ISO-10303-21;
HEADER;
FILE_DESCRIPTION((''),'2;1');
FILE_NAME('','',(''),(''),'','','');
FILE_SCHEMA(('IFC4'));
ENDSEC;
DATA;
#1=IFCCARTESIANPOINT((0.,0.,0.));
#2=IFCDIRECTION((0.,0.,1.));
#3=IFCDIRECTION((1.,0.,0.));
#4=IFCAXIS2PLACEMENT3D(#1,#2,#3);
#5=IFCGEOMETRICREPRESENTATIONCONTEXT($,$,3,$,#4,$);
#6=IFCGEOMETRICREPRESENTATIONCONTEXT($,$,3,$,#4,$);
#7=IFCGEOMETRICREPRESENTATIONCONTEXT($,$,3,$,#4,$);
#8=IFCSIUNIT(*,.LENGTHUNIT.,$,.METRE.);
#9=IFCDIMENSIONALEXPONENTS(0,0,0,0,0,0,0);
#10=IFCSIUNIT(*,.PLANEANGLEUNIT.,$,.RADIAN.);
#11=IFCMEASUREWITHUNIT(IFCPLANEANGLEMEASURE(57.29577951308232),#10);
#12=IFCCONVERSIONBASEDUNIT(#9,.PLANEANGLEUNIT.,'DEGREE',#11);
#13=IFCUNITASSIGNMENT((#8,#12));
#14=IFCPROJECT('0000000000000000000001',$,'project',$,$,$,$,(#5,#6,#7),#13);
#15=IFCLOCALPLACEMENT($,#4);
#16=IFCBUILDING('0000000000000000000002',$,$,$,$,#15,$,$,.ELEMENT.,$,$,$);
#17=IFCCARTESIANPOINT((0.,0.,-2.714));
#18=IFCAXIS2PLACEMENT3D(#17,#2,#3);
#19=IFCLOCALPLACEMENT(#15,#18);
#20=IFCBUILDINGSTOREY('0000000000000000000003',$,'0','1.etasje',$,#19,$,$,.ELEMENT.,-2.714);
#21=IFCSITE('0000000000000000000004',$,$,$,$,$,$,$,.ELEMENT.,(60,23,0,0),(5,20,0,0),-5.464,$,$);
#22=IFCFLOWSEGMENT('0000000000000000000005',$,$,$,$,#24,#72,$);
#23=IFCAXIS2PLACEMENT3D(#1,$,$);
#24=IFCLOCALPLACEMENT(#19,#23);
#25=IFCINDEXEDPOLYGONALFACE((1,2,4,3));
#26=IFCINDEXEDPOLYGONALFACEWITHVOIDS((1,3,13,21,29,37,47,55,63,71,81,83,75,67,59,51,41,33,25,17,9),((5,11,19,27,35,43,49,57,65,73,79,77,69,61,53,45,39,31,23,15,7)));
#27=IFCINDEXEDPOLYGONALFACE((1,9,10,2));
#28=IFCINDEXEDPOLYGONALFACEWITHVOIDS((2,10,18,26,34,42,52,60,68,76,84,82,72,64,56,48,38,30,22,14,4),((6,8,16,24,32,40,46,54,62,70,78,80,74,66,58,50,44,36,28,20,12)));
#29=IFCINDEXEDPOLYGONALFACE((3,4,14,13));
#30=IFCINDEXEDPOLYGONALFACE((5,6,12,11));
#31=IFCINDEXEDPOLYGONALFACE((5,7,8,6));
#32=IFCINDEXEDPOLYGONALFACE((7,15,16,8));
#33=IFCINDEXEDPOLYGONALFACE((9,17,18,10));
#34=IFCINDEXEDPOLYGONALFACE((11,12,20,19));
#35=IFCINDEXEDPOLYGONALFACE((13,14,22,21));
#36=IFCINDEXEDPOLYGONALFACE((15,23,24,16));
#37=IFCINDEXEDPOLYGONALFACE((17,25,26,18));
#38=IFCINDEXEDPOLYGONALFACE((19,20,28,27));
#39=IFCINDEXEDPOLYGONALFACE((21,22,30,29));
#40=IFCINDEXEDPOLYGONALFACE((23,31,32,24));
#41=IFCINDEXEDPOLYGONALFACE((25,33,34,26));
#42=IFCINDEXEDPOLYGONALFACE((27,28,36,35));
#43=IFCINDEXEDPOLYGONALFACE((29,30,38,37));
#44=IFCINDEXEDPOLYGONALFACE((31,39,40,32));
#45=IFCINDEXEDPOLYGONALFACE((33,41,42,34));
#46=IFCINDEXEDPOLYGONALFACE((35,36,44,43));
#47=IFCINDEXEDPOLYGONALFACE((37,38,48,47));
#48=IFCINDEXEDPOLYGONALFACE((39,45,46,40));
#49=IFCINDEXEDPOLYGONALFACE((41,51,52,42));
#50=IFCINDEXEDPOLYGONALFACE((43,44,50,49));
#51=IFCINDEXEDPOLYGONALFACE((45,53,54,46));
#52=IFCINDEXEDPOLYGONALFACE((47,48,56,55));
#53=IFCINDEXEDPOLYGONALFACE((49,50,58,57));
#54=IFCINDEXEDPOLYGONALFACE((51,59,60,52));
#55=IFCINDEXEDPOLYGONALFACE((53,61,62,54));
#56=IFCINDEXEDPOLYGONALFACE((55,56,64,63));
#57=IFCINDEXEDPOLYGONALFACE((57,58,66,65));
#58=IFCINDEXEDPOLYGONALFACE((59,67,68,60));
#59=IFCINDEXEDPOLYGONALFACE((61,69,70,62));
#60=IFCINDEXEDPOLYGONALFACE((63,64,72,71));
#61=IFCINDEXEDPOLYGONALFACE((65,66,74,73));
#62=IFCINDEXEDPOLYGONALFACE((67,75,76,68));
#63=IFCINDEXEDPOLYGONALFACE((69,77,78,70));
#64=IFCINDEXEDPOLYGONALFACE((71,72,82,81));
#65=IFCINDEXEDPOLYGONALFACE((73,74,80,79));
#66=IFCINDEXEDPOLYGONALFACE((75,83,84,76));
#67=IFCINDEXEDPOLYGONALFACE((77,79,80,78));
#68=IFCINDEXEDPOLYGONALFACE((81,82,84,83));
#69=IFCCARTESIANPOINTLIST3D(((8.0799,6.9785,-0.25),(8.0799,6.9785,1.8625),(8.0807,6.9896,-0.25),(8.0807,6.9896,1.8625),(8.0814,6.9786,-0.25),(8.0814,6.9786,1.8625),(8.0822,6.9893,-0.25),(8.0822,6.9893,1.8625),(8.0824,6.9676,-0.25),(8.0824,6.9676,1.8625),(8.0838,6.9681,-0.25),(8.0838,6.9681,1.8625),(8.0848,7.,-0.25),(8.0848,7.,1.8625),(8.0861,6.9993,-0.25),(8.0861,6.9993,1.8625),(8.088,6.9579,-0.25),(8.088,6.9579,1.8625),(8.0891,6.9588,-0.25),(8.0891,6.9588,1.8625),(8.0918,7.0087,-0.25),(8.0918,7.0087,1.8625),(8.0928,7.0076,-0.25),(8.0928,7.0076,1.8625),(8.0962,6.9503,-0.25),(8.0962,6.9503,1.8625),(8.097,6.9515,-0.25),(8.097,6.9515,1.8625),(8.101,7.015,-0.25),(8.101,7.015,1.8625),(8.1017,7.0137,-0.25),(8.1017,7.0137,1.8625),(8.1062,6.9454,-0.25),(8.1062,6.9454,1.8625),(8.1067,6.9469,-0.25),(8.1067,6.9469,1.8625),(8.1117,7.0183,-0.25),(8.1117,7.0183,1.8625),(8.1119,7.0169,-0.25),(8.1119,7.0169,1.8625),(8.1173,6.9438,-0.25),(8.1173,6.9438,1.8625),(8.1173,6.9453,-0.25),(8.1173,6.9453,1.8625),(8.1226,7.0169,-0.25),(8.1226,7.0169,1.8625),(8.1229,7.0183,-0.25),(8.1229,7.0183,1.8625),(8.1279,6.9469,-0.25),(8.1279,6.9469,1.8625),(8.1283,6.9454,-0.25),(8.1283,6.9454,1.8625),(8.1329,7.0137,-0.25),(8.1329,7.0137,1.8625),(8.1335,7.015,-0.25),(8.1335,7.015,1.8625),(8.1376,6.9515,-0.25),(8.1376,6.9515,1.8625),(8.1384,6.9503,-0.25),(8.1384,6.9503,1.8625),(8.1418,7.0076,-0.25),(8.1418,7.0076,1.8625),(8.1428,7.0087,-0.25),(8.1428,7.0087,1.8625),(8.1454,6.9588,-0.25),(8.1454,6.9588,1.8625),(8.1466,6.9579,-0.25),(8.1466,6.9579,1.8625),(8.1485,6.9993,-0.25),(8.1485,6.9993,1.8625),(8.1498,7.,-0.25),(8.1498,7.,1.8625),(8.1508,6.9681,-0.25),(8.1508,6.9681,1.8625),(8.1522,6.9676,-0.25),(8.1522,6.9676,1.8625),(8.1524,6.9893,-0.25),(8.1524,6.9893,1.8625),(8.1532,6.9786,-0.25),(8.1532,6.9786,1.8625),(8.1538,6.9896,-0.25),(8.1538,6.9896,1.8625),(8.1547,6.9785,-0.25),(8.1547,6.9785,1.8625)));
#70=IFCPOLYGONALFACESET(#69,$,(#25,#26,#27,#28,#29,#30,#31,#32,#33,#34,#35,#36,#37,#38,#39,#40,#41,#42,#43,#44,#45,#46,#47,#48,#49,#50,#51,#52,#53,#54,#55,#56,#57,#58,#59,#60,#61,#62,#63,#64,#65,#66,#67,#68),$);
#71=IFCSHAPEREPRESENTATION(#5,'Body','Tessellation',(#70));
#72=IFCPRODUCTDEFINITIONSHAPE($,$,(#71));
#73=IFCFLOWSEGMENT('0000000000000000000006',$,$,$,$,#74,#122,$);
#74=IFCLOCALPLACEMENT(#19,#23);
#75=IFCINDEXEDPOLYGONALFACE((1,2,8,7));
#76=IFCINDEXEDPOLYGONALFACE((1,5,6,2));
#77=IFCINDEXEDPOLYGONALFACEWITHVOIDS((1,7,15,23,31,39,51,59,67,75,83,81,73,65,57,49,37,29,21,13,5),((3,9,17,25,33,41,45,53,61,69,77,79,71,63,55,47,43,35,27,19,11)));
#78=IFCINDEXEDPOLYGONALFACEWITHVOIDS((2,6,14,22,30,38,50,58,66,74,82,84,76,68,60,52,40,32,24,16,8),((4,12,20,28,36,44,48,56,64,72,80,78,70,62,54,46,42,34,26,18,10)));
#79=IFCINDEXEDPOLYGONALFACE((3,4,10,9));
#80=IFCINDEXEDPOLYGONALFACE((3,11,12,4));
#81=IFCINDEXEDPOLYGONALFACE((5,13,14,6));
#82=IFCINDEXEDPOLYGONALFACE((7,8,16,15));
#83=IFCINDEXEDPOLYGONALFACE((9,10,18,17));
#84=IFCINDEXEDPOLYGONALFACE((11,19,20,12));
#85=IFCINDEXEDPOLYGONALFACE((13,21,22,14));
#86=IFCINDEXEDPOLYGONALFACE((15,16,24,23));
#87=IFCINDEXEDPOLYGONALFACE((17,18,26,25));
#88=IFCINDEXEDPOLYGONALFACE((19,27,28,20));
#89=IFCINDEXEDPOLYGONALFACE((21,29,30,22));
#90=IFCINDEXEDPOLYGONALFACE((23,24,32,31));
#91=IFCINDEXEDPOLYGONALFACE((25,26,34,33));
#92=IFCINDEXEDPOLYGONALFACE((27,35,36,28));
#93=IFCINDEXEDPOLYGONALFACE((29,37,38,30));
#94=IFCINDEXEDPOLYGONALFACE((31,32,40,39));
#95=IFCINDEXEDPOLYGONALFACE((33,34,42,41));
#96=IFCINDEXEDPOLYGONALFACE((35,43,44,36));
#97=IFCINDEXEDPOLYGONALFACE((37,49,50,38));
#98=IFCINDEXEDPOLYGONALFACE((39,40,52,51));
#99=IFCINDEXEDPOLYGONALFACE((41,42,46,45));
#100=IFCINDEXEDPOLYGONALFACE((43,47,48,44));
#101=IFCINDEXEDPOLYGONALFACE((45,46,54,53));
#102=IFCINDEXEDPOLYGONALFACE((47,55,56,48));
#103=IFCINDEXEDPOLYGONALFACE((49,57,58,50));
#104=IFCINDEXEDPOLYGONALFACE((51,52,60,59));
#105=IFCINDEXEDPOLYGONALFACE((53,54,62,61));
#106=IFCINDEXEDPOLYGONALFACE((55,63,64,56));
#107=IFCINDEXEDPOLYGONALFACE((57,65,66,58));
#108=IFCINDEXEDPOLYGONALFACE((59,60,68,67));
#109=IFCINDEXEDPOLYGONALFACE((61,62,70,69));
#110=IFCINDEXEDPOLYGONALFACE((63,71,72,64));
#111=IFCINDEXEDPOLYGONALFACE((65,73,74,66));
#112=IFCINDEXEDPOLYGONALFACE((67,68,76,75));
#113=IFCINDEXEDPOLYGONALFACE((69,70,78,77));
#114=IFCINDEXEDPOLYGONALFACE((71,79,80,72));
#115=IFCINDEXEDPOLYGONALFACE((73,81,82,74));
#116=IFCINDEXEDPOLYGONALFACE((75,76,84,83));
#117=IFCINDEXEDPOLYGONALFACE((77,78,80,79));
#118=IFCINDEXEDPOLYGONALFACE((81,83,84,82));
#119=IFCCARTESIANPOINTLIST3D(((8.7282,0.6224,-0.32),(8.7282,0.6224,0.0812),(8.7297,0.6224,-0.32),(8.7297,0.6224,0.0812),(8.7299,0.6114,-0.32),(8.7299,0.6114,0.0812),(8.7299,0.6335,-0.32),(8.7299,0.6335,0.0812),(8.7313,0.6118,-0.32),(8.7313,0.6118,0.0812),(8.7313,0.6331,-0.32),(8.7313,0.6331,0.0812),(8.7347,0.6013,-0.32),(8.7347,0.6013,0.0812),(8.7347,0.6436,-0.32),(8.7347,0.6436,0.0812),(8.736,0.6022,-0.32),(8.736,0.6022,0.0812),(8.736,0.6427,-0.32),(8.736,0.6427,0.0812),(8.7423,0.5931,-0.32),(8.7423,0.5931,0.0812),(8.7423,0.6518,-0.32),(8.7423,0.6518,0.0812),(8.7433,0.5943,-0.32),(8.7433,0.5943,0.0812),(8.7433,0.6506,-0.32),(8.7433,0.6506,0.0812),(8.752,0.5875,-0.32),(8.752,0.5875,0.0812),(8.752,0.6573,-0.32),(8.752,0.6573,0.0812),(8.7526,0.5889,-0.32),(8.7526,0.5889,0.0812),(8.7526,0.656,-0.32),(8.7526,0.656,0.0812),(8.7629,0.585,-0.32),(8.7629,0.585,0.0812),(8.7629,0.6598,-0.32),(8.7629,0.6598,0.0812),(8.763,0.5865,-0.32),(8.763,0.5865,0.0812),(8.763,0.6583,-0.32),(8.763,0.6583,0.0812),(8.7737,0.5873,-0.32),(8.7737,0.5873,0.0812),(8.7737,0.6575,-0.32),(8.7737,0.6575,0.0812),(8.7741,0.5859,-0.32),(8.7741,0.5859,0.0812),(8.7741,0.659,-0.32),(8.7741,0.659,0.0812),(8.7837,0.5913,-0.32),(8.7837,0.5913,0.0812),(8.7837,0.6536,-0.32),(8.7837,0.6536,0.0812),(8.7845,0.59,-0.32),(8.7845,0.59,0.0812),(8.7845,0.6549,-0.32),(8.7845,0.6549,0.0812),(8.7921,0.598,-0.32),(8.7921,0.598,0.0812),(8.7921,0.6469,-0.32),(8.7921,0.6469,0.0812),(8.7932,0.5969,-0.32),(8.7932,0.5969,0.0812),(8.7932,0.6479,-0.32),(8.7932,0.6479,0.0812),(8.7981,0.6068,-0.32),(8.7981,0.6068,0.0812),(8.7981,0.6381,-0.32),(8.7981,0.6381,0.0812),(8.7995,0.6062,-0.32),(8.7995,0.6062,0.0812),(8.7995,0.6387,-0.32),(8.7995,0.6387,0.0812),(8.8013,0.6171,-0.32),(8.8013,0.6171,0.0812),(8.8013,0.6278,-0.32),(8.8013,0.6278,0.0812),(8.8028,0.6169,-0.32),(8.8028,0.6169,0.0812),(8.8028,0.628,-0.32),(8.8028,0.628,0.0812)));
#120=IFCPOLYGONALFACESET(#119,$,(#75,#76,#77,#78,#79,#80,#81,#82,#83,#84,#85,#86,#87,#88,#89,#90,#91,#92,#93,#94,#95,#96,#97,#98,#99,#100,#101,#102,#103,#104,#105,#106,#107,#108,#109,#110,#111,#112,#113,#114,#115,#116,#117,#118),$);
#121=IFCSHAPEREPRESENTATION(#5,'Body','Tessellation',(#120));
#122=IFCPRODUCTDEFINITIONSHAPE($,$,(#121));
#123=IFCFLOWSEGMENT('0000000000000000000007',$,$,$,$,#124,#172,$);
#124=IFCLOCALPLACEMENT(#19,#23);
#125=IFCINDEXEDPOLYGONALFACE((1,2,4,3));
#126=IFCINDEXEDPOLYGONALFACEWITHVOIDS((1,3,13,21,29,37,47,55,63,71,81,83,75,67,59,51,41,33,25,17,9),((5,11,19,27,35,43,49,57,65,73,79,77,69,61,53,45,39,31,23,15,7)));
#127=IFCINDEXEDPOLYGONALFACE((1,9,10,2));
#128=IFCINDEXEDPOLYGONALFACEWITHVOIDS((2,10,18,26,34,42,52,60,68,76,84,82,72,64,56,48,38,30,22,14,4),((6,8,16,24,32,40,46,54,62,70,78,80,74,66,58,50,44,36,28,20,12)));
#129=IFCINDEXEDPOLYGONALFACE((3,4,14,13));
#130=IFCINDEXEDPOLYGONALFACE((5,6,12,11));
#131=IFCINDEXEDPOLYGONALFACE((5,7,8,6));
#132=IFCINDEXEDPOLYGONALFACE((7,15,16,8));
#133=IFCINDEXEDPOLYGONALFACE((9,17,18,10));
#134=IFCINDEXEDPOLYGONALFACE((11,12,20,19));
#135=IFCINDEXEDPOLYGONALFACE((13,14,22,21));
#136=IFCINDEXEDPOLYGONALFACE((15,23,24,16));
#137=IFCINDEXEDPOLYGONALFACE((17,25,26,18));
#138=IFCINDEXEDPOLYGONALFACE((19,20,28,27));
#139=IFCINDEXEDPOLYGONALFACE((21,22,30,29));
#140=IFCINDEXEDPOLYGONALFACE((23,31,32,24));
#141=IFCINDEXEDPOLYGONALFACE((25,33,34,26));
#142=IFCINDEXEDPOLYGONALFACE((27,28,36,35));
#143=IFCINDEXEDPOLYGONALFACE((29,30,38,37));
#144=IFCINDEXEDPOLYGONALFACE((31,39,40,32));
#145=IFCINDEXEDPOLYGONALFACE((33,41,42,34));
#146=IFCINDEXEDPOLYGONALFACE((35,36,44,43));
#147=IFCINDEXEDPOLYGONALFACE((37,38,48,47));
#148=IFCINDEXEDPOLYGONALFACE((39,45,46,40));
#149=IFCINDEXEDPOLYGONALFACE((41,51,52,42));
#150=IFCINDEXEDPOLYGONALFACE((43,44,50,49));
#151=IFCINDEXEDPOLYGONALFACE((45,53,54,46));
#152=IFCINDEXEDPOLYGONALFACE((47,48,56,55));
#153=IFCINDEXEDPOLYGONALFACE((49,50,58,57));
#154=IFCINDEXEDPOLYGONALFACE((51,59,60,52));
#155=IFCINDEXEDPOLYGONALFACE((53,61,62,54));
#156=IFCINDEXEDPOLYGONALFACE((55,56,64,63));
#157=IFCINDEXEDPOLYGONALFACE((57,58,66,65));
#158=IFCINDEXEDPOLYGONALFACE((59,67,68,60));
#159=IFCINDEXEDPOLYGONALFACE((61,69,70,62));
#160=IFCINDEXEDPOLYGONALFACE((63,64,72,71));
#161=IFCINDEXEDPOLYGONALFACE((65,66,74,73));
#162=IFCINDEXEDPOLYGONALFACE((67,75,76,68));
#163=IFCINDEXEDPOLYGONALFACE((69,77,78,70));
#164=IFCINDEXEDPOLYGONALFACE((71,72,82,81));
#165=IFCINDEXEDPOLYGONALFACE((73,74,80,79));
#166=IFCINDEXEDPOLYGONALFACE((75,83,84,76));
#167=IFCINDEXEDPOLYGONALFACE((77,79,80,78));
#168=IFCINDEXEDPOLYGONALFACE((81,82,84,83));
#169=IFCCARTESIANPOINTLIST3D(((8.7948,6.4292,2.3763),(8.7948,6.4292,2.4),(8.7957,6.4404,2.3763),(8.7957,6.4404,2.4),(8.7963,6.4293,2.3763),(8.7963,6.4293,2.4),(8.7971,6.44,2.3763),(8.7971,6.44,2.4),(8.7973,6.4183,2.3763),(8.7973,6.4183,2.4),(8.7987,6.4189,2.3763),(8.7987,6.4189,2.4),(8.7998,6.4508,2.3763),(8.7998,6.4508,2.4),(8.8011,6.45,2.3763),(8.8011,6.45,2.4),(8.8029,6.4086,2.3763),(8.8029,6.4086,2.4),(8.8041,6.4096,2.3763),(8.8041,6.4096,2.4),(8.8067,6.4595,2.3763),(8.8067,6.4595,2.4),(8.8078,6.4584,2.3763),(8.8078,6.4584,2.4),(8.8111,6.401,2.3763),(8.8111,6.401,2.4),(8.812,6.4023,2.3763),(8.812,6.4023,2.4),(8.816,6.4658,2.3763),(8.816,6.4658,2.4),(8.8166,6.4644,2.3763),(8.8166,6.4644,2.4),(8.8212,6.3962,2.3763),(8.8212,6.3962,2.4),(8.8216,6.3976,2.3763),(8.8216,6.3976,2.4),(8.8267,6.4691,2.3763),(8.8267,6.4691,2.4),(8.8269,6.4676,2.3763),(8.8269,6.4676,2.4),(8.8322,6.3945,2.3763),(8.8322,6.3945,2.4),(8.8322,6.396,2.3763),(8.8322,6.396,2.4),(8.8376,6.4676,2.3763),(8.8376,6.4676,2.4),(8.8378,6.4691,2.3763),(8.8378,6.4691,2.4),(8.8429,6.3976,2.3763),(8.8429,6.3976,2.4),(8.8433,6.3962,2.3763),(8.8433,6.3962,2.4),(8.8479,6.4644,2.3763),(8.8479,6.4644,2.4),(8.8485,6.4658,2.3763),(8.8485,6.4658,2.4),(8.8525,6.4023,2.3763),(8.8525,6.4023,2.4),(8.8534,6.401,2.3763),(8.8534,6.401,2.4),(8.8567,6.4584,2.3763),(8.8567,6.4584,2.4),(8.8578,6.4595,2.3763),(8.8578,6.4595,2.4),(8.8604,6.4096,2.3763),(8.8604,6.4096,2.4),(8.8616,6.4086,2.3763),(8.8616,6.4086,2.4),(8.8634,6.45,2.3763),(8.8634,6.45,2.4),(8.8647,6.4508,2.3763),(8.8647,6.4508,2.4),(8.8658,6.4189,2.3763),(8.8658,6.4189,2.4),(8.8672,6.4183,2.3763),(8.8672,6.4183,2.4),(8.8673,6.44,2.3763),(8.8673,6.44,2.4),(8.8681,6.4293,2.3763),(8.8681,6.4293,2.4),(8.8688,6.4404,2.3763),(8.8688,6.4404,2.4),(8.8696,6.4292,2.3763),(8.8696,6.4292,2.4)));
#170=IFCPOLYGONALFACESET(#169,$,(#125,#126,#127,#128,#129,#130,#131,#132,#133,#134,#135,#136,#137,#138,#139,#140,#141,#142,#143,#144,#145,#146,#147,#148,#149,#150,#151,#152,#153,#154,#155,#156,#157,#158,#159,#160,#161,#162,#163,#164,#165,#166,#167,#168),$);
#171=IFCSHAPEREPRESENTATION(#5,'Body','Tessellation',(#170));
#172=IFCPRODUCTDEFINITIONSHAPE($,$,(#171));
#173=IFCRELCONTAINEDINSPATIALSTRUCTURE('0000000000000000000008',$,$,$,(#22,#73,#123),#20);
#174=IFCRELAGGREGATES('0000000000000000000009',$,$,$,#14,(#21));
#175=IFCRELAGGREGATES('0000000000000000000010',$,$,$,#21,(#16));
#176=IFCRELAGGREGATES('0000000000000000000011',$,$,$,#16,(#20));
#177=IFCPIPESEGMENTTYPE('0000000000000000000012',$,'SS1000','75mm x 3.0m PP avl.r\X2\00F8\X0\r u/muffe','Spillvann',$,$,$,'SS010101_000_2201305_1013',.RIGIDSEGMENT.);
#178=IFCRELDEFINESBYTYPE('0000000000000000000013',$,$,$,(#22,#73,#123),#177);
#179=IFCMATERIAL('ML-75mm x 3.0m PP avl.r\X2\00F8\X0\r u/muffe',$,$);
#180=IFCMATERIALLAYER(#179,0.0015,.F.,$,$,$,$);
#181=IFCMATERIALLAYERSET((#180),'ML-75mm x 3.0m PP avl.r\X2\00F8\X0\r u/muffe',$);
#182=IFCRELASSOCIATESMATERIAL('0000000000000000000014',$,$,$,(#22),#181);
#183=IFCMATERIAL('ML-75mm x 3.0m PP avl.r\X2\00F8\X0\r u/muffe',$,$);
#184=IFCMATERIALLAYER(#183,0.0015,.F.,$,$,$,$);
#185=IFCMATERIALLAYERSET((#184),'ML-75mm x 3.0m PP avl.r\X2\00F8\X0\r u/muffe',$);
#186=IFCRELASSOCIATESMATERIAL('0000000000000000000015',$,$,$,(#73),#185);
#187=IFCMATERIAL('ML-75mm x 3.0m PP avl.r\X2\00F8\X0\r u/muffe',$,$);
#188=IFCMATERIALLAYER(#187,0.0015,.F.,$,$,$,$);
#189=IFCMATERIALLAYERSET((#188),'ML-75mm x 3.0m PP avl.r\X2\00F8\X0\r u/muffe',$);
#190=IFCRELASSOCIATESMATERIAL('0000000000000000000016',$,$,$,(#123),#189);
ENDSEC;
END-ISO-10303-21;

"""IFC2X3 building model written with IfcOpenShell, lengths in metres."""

from ifc_helpers import new_model, entity, si_unit, converted_unit, frame, origin_with_axes, origin_2d_with_axis, place, context, project, spatial, hollow_circle, extrude, material, layer, layer_set, layer_usage, type_object, element, save


model = new_model("IFC2X3")

# Units and contexts
context_of_model_1 = context(None, 3, world=origin_with_axes())
context_of_model_2 = context(None, 3, world=origin_with_axes())
context_of_model_3 = context(None, 3, world=origin_with_axes())
ifc_project = project(units=[si_unit("LENGTHUNIT", "METRE"), converted_unit("PLANEANGLEUNIT", "DEGREE", entity("IfcPlaneAngleMeasure", 57.29577951308232), si_unit("PLANEANGLEUNIT", "RADIAN"), dimensions=[0, 0, 0, 0, 0, 0, 0])], contexts=[context_of_model_1, context_of_model_2, context_of_model_3])

# Site, building, storey
site = spatial("IfcSite", under=ifc_project, CompositionType="ELEMENT", RefLatitude=(60, 23, 0, 0), RefLongitude=(5, 20, 0, 0), RefElevation=-5.464)
building_placement = place(None, origin_with_axes())
building = spatial("IfcBuilding", under=site, at=building_placement, CompositionType="ELEMENT")
storey_placement = place(building_placement, frame((0.0, 0.0, -2.714), z_axis=(0.0, 0.0, 1.0), x_axis=(1.0, 0.0, 0.0)))
storey = spatial("IfcBuildingStorey", under=building, at=storey_placement, Name="0", Description="1.etasje", CompositionType="ELEMENT", Elevation=-2.714)

# Flow segments
pipe_segment_type_1 = type_object("IfcPipeSegmentType", Name="SS1000", Description="75mm x 3.0m PP avl.rør u/muffe", ApplicableOccurrence="Spillvann", ElementType="SS010101_000_2201305_1013", PredefinedType="RIGIDSEGMENT")
ifc_material_1 = material(Name="ML-75mm x 3.0m PP avl.rør u/muffe")
ifc_layer_1 = layer(ifc_material_1, 0.0015, ventilated=False)
ifc_layer_set_1 = layer_set([ifc_layer_1], Name="ML-75mm x 3.0m PP avl.rør u/muffe")
ifc_layer_usage_1 = layer_usage(ifc_layer_set_1, "AXIS2", "POSITIVE", 0.0)
flow_segment_1_placement = place(storey_placement, frame((8.1173, 6.9813, 1.8625), z_axis=(0.0, 0.0, -1.0), x_axis=(0.0, -1.0, 0.0)))
element("IfcFlowSegment", 1, at=flow_segment_1_placement, inside=storey, type_object=pipe_segment_type_1, material=ifc_layer_usage_1, context=context_of_model_1, shape_type="SweptSolid", body=[
    extrude(hollow_circle(Radius=0.0375, WallThickness=0.0015, at=origin_2d_with_axis()), origin_with_axes(), (0.0, 0.0, 1.0), 2.1125),
])
ifc_material_2 = material(Name="ML-75mm x 3.0m PP avl.rør u/muffe")
ifc_layer_2 = layer(ifc_material_2, 0.0015, ventilated=False)
ifc_layer_set_2 = layer_set([ifc_layer_2], Name="ML-75mm x 3.0m PP avl.rør u/muffe")
ifc_layer_usage_2 = layer_usage(ifc_layer_set_2, "AXIS2", "POSITIVE", 0.0)
flow_segment_2_placement = place(storey_placement, frame((8.7657, 0.6224, 0.0812), z_axis=(0.0, 0.0, -1.0), x_axis=(-1.0, 0.0, 0.0)))
element("IfcFlowSegment", 2, at=flow_segment_2_placement, inside=storey, type_object=pipe_segment_type_1, material=ifc_layer_usage_2, context=context_of_model_1, shape_type="SweptSolid", body=[
    extrude(hollow_circle(Radius=0.0375, WallThickness=0.0015, at=origin_2d_with_axis()), origin_with_axes(), (0.0, 0.0, 1.0), 0.4012),
])
ifc_material_3 = material(Name="ML-75mm x 3.0m PP avl.rør u/muffe")
ifc_layer_3 = layer(ifc_material_3, 0.0015, ventilated=False)
ifc_layer_set_3 = layer_set([ifc_layer_3], Name="ML-75mm x 3.0m PP avl.rør u/muffe")
ifc_layer_usage_3 = layer_usage(ifc_layer_set_3, "AXIS2", "POSITIVE", 0.0)
flow_segment_3_placement = place(storey_placement, frame((8.8322, 6.432, 2.4), z_axis=(0.0, 0.0, -1.0), x_axis=(0.0, -1.0, 0.0)))
element("IfcFlowSegment", 3, at=flow_segment_3_placement, inside=storey, type_object=pipe_segment_type_1, material=ifc_layer_usage_3, context=context_of_model_1, shape_type="SweptSolid", body=[
    extrude(hollow_circle(Radius=0.0375, WallThickness=0.0015, at=origin_2d_with_axis()), origin_with_axes(), (0.0, 0.0, 1.0), 0.0237),
])

save(model, "model.ifc")
